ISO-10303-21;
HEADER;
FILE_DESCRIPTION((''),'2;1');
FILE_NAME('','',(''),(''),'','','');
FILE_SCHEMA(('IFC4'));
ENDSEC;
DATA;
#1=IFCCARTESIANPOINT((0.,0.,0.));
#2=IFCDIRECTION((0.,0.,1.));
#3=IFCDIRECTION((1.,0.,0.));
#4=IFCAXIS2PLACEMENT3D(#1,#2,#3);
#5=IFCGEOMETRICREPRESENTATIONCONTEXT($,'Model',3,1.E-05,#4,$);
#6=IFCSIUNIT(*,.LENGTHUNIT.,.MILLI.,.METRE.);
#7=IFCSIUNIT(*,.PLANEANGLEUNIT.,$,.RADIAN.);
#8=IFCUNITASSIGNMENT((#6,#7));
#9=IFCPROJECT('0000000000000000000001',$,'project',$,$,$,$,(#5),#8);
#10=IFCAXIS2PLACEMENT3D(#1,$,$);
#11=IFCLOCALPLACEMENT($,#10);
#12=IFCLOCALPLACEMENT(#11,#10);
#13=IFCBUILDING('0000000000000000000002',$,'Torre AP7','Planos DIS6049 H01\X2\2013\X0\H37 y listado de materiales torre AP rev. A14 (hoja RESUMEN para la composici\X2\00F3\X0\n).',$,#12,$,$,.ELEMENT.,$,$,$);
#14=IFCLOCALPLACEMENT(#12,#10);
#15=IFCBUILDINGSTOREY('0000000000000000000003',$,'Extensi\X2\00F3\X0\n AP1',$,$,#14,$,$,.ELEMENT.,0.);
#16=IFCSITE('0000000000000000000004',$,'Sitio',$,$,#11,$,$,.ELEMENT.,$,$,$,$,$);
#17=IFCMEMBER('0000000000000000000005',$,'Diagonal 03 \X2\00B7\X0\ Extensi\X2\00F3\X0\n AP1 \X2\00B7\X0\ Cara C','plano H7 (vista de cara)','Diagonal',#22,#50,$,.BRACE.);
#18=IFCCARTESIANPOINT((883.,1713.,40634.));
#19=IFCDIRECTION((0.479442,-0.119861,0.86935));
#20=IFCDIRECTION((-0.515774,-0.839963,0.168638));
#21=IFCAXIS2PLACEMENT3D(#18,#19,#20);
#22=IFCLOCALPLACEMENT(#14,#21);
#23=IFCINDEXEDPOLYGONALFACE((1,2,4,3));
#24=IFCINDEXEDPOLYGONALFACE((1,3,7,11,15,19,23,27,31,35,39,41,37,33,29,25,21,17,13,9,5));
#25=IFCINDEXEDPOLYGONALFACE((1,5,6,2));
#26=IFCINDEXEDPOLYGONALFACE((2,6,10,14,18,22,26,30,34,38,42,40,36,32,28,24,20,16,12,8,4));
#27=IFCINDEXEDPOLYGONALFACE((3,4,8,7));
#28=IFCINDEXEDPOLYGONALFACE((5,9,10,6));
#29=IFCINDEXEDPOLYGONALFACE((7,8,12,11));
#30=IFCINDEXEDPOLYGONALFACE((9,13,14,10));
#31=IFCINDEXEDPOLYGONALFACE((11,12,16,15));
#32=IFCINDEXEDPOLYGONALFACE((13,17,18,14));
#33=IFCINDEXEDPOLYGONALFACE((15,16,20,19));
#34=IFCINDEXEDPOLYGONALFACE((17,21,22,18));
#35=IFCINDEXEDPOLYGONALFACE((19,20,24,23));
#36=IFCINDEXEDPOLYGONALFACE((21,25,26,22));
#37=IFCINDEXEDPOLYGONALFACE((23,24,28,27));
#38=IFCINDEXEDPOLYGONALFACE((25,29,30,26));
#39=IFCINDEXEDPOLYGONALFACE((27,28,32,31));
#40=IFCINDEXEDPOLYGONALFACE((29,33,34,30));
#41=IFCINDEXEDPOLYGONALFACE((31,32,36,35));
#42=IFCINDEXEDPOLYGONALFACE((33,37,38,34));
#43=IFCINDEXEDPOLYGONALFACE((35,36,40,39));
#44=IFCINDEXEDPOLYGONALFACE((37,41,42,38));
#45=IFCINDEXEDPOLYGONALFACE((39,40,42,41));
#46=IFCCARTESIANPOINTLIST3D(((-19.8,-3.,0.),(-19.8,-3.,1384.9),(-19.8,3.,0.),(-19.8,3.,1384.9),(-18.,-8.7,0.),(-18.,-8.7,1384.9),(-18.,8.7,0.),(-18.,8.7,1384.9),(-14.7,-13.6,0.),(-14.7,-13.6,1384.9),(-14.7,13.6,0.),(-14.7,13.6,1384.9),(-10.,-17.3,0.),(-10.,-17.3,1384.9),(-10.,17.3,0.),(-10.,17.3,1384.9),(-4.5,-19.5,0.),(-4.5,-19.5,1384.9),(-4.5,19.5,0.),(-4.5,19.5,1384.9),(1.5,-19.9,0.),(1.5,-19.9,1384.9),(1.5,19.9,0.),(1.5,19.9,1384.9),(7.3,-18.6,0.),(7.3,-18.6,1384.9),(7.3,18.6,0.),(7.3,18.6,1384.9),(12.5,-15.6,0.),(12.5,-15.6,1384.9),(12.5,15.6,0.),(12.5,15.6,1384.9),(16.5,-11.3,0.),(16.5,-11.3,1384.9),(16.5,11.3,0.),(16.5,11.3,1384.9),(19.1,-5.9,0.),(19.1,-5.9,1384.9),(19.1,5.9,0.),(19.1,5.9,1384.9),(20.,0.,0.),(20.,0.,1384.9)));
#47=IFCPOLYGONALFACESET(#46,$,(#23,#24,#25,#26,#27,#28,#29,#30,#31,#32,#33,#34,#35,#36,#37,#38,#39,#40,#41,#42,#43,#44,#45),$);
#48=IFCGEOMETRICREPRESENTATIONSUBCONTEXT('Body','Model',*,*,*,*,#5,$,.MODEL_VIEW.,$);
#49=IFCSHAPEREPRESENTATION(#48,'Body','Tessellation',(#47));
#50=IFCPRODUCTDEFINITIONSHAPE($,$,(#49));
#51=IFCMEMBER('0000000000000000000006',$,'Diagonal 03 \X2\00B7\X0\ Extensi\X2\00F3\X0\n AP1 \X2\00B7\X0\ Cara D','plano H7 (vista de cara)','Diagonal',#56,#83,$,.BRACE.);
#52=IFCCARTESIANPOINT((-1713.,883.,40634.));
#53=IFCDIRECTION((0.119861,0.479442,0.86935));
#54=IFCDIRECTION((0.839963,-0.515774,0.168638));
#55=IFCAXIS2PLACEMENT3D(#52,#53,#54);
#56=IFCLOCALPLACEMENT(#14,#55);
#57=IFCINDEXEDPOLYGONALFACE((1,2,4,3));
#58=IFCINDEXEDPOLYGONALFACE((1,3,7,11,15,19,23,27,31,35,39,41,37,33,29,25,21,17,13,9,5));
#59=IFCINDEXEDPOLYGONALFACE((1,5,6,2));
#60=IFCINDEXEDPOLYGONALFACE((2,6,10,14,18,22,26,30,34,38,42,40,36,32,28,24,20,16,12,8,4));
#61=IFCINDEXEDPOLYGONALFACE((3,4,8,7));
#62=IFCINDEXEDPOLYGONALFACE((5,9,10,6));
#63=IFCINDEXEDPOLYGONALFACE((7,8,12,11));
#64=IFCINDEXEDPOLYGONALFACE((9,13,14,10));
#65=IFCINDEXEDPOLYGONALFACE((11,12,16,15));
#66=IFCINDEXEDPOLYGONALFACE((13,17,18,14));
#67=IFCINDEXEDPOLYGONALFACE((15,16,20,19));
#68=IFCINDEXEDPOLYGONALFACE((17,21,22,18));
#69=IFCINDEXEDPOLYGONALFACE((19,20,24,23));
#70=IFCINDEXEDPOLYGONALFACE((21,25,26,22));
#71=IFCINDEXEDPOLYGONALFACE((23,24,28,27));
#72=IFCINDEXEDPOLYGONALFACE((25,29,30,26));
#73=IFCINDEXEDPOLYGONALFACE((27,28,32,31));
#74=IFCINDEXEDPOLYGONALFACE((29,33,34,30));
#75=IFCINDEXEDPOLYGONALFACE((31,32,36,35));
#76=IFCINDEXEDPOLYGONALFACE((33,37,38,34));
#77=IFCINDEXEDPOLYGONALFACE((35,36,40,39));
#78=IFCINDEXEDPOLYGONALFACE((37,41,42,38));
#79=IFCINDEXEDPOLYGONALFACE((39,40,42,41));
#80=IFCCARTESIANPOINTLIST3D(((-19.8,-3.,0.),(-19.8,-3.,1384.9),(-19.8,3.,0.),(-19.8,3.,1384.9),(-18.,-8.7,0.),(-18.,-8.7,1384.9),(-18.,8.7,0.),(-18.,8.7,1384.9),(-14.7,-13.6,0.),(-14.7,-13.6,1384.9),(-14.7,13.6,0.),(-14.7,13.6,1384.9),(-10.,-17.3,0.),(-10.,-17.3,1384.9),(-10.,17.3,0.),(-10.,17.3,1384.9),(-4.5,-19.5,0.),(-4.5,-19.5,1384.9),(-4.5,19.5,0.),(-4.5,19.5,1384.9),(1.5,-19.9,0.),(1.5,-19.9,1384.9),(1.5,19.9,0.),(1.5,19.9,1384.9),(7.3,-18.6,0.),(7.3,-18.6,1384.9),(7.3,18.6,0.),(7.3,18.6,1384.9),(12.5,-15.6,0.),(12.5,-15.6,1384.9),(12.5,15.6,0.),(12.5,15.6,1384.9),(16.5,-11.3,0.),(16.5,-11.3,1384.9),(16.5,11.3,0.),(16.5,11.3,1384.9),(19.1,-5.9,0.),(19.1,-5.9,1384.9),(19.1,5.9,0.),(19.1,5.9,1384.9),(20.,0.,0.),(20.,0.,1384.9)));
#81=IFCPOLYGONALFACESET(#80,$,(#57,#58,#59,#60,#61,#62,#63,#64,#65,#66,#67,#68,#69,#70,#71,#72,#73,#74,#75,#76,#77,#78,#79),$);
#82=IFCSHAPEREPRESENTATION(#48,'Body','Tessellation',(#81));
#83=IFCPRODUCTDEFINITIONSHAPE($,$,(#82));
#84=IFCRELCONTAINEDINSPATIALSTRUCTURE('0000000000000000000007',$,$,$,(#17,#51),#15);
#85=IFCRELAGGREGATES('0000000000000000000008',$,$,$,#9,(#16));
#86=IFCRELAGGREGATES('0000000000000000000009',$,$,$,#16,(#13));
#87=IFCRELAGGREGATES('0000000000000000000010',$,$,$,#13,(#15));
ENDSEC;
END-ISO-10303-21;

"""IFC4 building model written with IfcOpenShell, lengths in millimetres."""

from ifc_helpers import new_model, si_unit, frame, origin, origin_with_axes, place, context, subcontext, project, spatial, circle, extrude, element, save


model = new_model("IFC4")

# Units and contexts
model_context = context("Model", 3, precision=1e-05, world=origin_with_axes())
body_context = subcontext(model_context, "Body", "Model", "MODEL_VIEW")
ifc_project = project(units=[si_unit("LENGTHUNIT", "METRE", prefix="MILLI"), si_unit("PLANEANGLEUNIT", "RADIAN")], contexts=[model_context])

# Site, building, storey
site_placement = place(None, origin())
site = spatial("IfcSite", under=ifc_project, at=site_placement, Name="Sitio", CompositionType="ELEMENT")
building_placement = place(site_placement, origin())
building = spatial("IfcBuilding", under=site, at=building_placement, Name="Torre AP7", Description="Planos DIS6049 H01–H37 y listado de materiales torre AP rev. A14 (hoja RESUMEN para la composición).", CompositionType="ELEMENT")
storey_placement = place(building_placement, origin())
storey = spatial("IfcBuildingStorey", under=building, at=storey_placement, Name="Extensión AP1", CompositionType="ELEMENT", Elevation=0.0)

# Members
for number, where, z_axis, x_axis, name in (
    (1, (883.0, 1713.0, 40634.0), (0.479442, -0.119861, 0.86935), (-0.515774, -0.839963, 0.168638), "Diagonal 03 · Extensión AP1 · Cara C"),
    (2, (-1713.0, 883.0, 40634.0), (0.119861, 0.479442, 0.86935), (0.839963, -0.515774, 0.168638), "Diagonal 03 · Extensión AP1 · Cara D"),
):
    element("IfcMember", number, at=place(storey_placement, frame(where, z_axis=z_axis, x_axis=x_axis)), inside=storey, Name=name, Description="plano H7 (vista de cara)", ObjectType="Diagonal", PredefinedType="BRACE", context=body_context, shape_type="SweptSolid", body=[
        extrude(circle(Radius=20.0), None, (0.0, 0.0, 1.0), 1384.9),
    ])

save(model, "model.ifc")
